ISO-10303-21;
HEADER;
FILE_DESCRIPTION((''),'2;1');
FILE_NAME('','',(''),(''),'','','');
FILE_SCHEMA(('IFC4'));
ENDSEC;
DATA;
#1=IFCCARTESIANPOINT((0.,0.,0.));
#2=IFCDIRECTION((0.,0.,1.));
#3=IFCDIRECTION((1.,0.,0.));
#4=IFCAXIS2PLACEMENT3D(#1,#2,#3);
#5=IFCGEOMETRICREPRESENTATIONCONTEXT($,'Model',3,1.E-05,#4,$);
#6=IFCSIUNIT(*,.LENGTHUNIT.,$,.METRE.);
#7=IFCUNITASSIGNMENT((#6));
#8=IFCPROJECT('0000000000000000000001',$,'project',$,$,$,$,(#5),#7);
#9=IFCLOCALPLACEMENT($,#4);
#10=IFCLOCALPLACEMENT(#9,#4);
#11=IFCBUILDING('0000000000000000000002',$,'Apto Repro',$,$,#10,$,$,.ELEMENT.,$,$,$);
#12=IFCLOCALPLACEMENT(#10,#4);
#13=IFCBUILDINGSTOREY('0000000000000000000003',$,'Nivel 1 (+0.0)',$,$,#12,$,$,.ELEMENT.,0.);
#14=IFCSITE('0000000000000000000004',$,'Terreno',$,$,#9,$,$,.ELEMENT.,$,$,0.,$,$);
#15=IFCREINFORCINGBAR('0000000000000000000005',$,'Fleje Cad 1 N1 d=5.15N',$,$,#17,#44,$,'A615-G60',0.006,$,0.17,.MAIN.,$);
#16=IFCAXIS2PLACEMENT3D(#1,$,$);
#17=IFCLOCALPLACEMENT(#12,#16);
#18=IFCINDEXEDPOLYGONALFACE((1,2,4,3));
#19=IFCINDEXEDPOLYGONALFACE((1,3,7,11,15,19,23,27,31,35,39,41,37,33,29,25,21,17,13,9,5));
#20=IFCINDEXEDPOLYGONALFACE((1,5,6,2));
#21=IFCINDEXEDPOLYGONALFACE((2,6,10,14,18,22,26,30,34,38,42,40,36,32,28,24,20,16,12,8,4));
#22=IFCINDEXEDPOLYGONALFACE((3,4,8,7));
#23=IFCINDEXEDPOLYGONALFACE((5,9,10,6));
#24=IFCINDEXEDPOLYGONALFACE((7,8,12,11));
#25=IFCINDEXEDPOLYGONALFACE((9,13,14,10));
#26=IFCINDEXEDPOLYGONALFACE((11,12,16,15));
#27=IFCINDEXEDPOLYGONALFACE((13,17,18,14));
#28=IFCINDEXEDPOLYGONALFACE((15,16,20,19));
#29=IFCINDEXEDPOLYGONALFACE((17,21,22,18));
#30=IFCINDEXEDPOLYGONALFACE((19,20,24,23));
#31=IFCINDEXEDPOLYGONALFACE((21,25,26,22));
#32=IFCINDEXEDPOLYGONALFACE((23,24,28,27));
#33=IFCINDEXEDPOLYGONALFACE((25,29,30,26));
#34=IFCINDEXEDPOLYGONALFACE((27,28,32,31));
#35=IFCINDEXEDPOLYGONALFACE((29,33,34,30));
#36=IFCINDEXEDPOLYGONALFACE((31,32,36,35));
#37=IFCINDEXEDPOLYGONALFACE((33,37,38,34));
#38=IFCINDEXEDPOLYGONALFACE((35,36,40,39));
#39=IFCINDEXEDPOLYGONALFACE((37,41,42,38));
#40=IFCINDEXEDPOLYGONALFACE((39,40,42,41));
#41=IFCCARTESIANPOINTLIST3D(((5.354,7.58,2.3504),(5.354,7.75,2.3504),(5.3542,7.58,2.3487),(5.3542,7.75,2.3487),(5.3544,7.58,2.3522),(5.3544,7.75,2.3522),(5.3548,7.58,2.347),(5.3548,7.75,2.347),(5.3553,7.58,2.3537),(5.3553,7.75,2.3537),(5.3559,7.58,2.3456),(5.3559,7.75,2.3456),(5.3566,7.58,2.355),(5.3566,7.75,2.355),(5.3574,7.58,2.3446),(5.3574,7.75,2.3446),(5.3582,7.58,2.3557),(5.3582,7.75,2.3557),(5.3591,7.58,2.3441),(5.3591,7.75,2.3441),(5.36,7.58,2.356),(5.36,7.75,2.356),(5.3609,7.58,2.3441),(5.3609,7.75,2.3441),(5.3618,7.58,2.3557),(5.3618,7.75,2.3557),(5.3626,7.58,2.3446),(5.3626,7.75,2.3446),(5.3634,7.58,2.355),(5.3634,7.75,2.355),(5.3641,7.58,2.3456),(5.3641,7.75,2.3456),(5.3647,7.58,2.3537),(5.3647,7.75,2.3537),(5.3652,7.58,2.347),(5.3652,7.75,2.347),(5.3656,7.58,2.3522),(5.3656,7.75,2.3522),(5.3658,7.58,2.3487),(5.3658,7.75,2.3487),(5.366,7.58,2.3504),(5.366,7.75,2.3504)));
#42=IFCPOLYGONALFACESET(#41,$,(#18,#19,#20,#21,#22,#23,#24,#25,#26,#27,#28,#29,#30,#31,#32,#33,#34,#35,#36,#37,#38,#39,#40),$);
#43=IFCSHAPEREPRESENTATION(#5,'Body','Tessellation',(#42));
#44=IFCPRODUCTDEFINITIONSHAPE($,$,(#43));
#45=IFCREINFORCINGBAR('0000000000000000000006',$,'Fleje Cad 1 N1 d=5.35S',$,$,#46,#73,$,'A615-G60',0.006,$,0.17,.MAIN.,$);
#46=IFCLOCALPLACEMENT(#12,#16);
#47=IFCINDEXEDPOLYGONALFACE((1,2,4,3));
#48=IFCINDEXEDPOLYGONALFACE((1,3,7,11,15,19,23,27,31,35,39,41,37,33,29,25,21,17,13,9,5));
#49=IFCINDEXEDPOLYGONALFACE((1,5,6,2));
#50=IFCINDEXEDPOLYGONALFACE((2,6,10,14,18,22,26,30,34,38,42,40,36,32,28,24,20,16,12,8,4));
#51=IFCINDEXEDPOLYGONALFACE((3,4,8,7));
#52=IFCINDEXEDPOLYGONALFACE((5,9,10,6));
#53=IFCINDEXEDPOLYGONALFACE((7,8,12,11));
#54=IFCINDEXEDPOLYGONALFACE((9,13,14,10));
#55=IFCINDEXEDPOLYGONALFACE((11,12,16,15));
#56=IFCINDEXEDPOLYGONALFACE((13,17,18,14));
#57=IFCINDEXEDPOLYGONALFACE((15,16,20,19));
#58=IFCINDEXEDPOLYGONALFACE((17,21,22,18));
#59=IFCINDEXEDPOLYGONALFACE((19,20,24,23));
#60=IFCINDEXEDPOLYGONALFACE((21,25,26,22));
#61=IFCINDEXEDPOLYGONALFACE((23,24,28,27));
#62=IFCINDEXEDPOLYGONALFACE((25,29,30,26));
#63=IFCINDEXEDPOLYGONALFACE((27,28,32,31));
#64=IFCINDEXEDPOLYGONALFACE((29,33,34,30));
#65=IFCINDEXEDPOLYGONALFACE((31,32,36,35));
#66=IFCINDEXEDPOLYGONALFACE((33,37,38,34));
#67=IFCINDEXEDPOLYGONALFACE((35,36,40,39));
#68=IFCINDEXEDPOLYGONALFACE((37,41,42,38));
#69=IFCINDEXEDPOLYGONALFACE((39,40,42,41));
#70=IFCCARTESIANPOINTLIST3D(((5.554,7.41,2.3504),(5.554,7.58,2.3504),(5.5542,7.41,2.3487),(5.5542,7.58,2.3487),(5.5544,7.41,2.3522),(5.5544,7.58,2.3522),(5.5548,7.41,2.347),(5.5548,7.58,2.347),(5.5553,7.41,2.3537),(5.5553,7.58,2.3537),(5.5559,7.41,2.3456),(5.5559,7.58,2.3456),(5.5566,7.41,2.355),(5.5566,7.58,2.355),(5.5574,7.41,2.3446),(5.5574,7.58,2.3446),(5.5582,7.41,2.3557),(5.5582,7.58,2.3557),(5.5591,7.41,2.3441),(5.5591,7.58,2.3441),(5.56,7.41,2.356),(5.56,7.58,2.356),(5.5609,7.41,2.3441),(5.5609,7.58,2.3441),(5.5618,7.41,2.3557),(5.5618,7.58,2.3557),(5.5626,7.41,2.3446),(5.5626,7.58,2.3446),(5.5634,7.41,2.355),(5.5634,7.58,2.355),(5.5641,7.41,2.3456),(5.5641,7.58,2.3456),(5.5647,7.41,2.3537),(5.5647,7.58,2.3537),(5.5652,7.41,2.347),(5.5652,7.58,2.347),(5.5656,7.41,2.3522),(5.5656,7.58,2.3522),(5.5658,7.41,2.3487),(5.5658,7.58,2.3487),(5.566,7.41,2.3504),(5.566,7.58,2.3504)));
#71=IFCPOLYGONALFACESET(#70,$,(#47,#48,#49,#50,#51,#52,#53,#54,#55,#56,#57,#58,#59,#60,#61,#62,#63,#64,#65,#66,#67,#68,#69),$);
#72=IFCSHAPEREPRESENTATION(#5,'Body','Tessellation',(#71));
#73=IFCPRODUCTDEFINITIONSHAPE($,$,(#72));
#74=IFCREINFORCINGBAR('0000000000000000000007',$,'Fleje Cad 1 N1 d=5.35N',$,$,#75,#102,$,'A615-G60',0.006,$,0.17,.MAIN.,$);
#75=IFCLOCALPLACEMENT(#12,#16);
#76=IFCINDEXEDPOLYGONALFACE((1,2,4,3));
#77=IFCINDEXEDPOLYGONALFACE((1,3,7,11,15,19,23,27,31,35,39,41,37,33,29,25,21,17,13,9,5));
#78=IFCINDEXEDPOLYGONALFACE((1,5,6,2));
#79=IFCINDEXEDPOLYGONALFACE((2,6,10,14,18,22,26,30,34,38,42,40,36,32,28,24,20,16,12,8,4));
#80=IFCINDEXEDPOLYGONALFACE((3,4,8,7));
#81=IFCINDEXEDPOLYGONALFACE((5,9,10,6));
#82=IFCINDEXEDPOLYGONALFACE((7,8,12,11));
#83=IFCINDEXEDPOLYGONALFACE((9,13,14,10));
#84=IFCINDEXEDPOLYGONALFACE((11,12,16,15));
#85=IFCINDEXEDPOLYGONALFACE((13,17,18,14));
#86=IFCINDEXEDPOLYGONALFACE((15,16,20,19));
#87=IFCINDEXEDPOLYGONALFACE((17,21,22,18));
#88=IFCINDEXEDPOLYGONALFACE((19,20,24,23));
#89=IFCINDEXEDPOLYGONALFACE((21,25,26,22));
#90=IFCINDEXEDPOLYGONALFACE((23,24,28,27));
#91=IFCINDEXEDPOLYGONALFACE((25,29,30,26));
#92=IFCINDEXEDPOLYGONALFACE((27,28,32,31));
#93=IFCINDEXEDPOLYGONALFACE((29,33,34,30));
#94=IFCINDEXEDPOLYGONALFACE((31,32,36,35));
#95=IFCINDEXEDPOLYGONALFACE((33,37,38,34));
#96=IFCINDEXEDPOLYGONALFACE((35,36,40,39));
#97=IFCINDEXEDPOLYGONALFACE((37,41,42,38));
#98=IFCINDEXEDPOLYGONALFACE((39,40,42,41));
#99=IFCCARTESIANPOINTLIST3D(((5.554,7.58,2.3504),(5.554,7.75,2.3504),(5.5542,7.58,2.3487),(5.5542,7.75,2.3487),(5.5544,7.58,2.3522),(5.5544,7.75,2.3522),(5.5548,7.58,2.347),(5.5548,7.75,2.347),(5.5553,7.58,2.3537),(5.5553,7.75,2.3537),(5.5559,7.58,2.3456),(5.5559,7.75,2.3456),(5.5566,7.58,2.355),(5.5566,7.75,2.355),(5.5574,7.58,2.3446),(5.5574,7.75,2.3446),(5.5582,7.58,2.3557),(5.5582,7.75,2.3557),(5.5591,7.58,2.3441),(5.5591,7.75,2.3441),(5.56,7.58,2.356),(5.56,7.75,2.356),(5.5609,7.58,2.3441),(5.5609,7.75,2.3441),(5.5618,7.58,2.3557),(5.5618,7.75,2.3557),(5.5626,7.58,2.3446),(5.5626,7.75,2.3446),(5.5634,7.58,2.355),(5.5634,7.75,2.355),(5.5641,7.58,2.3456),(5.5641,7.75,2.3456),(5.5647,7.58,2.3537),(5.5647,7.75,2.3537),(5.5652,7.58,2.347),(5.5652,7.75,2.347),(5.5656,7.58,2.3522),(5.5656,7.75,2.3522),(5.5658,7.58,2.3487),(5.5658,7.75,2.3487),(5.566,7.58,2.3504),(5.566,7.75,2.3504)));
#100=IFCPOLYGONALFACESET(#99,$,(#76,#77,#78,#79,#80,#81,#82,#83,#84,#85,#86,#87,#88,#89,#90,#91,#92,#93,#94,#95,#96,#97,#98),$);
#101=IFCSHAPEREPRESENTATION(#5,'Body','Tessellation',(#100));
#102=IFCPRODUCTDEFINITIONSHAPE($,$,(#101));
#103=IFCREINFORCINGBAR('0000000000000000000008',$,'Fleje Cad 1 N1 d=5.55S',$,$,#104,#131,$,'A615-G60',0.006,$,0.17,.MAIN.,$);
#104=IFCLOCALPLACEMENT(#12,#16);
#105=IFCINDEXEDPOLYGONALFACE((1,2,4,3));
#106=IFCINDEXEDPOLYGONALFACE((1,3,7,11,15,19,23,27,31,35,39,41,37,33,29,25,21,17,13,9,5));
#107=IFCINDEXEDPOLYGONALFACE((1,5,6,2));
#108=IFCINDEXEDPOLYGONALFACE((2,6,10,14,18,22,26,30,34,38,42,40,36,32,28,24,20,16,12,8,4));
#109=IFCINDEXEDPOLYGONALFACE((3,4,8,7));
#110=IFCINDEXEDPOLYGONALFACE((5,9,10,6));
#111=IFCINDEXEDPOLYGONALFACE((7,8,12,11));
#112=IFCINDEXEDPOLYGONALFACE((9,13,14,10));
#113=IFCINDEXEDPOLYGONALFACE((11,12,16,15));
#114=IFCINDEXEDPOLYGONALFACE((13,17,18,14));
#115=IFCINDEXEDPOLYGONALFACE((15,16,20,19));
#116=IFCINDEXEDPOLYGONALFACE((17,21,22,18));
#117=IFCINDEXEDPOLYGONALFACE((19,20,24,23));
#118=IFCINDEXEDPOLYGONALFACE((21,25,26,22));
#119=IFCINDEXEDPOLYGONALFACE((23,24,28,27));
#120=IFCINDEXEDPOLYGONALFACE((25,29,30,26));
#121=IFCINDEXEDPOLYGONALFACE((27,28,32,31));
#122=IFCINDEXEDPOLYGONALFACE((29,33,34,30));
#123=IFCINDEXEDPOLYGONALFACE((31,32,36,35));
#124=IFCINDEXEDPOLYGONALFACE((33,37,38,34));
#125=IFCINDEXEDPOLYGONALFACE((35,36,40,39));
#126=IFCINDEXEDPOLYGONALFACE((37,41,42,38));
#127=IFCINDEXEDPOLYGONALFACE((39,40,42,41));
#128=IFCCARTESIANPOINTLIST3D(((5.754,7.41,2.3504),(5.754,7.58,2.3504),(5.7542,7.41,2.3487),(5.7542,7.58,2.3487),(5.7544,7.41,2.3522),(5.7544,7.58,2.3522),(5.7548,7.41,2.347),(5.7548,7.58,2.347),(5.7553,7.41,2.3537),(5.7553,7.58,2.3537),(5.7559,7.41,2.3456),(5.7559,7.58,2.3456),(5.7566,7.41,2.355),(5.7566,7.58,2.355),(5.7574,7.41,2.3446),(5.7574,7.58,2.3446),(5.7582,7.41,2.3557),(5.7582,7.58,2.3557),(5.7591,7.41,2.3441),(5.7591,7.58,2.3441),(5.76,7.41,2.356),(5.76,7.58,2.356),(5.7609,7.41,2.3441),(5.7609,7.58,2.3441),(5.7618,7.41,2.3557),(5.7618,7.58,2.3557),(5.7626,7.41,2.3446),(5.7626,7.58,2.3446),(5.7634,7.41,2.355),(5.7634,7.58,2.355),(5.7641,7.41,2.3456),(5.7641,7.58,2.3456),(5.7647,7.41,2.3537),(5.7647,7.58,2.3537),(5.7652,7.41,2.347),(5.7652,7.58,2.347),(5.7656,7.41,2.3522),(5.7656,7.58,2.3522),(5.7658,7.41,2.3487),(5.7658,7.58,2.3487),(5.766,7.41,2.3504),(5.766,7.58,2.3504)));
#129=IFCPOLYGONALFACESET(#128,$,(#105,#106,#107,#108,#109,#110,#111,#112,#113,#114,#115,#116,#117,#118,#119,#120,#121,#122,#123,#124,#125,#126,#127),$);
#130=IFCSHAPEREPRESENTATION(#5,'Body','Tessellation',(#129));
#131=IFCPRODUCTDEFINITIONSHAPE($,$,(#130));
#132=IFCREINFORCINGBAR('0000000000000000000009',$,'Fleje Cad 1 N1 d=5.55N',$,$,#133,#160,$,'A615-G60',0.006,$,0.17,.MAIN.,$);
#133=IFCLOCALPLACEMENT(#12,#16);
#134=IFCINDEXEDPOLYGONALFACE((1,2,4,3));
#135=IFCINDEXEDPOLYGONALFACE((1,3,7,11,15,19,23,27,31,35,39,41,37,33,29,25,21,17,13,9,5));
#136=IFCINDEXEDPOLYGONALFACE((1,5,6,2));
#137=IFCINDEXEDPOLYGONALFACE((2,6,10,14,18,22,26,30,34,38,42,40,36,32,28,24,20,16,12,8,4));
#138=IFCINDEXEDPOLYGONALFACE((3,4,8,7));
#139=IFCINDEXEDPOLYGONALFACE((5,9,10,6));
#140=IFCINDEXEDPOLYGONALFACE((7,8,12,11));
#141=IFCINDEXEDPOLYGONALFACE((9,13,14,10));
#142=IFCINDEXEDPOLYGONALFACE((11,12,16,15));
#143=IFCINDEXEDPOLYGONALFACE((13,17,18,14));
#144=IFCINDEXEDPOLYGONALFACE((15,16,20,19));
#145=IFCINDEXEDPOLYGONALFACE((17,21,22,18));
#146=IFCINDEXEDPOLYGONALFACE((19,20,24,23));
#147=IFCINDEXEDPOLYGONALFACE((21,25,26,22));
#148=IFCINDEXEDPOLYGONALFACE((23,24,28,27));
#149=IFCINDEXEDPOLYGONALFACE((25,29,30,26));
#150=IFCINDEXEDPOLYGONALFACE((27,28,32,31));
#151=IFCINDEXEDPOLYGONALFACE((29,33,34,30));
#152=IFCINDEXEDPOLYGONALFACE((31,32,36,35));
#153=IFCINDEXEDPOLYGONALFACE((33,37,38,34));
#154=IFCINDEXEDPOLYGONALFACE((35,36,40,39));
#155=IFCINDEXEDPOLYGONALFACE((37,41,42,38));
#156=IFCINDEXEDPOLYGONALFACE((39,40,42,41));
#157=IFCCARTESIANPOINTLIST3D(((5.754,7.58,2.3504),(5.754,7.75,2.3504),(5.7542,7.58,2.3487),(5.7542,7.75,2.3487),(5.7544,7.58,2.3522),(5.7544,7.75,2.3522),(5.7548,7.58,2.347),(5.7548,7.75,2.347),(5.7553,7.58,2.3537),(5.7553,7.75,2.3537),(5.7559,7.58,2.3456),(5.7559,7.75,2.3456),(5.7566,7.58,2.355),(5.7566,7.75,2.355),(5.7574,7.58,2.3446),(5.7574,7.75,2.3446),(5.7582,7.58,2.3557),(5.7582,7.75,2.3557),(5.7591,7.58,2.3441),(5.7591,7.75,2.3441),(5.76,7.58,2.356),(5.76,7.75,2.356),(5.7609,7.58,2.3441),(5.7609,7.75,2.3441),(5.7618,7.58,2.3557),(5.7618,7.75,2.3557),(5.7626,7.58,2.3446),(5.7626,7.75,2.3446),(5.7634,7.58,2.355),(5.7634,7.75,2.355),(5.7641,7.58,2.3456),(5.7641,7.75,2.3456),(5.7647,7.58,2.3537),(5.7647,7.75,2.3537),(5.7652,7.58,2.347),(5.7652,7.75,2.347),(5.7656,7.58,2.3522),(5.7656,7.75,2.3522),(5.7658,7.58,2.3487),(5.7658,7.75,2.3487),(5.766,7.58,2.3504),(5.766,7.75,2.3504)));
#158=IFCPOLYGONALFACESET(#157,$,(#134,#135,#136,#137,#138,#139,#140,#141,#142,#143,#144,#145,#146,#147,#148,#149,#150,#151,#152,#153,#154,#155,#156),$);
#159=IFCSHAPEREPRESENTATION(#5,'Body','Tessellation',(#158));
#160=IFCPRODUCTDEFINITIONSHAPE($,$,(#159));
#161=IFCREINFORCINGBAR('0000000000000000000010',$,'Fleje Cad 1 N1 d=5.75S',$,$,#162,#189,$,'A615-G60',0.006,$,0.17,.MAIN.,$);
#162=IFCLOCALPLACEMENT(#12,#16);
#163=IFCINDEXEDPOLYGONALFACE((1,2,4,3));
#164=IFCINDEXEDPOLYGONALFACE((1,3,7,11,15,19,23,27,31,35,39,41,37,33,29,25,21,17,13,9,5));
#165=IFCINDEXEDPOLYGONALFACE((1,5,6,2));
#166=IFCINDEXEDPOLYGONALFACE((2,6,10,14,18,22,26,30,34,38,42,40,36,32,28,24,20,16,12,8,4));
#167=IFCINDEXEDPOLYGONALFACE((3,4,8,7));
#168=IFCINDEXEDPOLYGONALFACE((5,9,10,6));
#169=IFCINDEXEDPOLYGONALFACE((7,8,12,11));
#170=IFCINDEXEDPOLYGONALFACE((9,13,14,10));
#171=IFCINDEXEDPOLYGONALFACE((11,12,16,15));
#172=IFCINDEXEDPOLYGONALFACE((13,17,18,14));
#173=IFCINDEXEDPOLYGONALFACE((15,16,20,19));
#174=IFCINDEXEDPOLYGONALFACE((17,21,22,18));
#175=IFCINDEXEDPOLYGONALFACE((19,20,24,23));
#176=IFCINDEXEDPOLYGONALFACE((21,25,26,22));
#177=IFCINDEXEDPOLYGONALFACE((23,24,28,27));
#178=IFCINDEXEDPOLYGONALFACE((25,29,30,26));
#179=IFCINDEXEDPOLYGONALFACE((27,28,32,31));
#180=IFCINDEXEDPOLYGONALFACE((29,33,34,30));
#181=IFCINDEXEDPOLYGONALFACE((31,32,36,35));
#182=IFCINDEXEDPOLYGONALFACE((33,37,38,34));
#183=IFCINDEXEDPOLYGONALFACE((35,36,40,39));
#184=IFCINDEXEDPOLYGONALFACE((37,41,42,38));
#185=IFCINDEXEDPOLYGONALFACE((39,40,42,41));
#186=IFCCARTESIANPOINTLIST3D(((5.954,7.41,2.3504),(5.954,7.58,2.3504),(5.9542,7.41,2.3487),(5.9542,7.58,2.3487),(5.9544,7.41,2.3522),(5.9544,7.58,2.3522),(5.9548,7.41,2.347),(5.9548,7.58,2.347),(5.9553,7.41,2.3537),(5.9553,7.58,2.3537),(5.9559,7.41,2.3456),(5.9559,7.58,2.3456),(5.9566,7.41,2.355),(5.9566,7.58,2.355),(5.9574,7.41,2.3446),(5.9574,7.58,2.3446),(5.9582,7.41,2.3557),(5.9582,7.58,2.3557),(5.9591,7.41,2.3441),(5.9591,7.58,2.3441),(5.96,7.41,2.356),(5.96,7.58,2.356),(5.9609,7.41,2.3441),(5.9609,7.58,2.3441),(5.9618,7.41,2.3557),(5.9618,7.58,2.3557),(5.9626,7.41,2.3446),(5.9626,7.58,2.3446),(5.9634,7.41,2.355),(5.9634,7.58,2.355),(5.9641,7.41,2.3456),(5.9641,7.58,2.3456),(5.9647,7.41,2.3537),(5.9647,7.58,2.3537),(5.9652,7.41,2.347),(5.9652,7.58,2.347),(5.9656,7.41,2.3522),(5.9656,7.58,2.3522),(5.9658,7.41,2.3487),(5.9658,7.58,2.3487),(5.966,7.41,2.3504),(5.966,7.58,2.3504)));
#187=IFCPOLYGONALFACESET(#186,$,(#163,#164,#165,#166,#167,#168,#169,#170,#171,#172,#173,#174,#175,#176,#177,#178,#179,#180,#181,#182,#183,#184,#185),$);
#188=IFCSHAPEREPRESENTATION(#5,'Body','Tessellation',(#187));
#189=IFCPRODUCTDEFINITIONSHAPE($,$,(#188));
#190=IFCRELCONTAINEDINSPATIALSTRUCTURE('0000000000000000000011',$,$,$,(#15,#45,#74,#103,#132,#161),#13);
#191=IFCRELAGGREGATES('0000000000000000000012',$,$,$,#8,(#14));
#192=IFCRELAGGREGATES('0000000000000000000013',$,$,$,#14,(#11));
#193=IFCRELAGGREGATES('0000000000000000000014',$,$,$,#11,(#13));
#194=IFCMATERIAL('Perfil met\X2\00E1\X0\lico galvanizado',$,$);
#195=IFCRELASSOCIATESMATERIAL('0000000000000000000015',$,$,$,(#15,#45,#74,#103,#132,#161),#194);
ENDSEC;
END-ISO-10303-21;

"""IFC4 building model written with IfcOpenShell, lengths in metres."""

from ifc_helpers import new_model, si_unit, frame, origin_with_axes, origin_2d_with_axis, place, context, project, spatial, circle, extrude, material, element, save


model = new_model("IFC4")

# Units and contexts
model_context = context("Model", 3, precision=1e-05, world=origin_with_axes())
ifc_project = project(units=[si_unit("LENGTHUNIT", "METRE")], contexts=[model_context])

# Site, building, storey
site_placement = place(None, origin_with_axes())
site = spatial("IfcSite", under=ifc_project, at=site_placement, Name="Terreno", CompositionType="ELEMENT", RefElevation=0.0)
building_placement = place(site_placement, origin_with_axes())
building = spatial("IfcBuilding", under=site, at=building_placement, Name="Apto Repro", CompositionType="ELEMENT")
storey_placement = place(building_placement, origin_with_axes())
storey = spatial("IfcBuildingStorey", under=building, at=storey_placement, Name="Nivel 1 (+0.0)", CompositionType="ELEMENT", Elevation=0.0)

# Reinforcing bars
ifc_material = material(Name="Perfil metálico galvanizado")
reinforcing_bar_1_placement = place(storey_placement, origin_with_axes())
element("IfcReinforcingBar", 1, at=reinforcing_bar_1_placement, inside=storey, material=ifc_material, Name="Fleje Cad 1 N1 d=5.15N", SteelGrade="A615-G60", BarLength=0.17, NominalDiameter=0.006, PredefinedType="MAIN", context=model_context, shape_type="SweptSolid", body=[
    extrude(circle(Radius=0.006, at=origin_2d_with_axis()), frame((5.36, 7.58, 2.35), z_axis=(0.0, 1.0, 0.0), x_axis=(0.0, 0.0, 1.0)), (0.0, 0.0, 1.0), 0.17),
])
reinforcing_bar_2_placement = place(storey_placement, origin_with_axes())
element("IfcReinforcingBar", 2, at=reinforcing_bar_2_placement, inside=storey, material=ifc_material, Name="Fleje Cad 1 N1 d=5.35S", SteelGrade="A615-G60", BarLength=0.17, NominalDiameter=0.006, PredefinedType="MAIN", context=model_context, shape_type="SweptSolid", body=[
    extrude(circle(Radius=0.006, at=origin_2d_with_axis()), frame((5.56, 7.41, 2.35), z_axis=(0.0, 1.0, 0.0), x_axis=(0.0, 0.0, 1.0)), (0.0, 0.0, 1.0), 0.17),
])
reinforcing_bar_3_placement = place(storey_placement, origin_with_axes())
element("IfcReinforcingBar", 3, at=reinforcing_bar_3_placement, inside=storey, material=ifc_material, Name="Fleje Cad 1 N1 d=5.35N", SteelGrade="A615-G60", BarLength=0.17, NominalDiameter=0.006, PredefinedType="MAIN", context=model_context, shape_type="SweptSolid", body=[
    extrude(circle(Radius=0.006, at=origin_2d_with_axis()), frame((5.56, 7.58, 2.35), z_axis=(0.0, 1.0, 0.0), x_axis=(0.0, 0.0, 1.0)), (0.0, 0.0, 1.0), 0.17),
])
reinforcing_bar_4_placement = place(storey_placement, origin_with_axes())
element("IfcReinforcingBar", 4, at=reinforcing_bar_4_placement, inside=storey, material=ifc_material, Name="Fleje Cad 1 N1 d=5.55S", SteelGrade="A615-G60", BarLength=0.17, NominalDiameter=0.006, PredefinedType="MAIN", context=model_context, shape_type="SweptSolid", body=[
    extrude(circle(Radius=0.006, at=origin_2d_with_axis()), frame((5.76, 7.41, 2.35), z_axis=(0.0, 1.0, 0.0), x_axis=(0.0, 0.0, 1.0)), (0.0, 0.0, 1.0), 0.17),
])
reinforcing_bar_5_placement = place(storey_placement, origin_with_axes())
element("IfcReinforcingBar", 5, at=reinforcing_bar_5_placement, inside=storey, material=ifc_material, Name="Fleje Cad 1 N1 d=5.55N", SteelGrade="A615-G60", BarLength=0.17, NominalDiameter=0.006, PredefinedType="MAIN", context=model_context, shape_type="SweptSolid", body=[
    extrude(circle(Radius=0.006, at=origin_2d_with_axis()), frame((5.76, 7.58, 2.35), z_axis=(0.0, 1.0, 0.0), x_axis=(0.0, 0.0, 1.0)), (0.0, 0.0, 1.0), 0.17),
])
reinforcing_bar_6_placement = place(storey_placement, origin_with_axes())
element("IfcReinforcingBar", 6, at=reinforcing_bar_6_placement, inside=storey, material=ifc_material, Name="Fleje Cad 1 N1 d=5.75S", SteelGrade="A615-G60", BarLength=0.17, NominalDiameter=0.006, PredefinedType="MAIN", context=model_context, shape_type="SweptSolid", body=[
    extrude(circle(Radius=0.006, at=origin_2d_with_axis()), frame((5.96, 7.41, 2.35), z_axis=(0.0, 1.0, 0.0), x_axis=(0.0, 0.0, 1.0)), (0.0, 0.0, 1.0), 0.17),
])

save(model, "model.ifc")
